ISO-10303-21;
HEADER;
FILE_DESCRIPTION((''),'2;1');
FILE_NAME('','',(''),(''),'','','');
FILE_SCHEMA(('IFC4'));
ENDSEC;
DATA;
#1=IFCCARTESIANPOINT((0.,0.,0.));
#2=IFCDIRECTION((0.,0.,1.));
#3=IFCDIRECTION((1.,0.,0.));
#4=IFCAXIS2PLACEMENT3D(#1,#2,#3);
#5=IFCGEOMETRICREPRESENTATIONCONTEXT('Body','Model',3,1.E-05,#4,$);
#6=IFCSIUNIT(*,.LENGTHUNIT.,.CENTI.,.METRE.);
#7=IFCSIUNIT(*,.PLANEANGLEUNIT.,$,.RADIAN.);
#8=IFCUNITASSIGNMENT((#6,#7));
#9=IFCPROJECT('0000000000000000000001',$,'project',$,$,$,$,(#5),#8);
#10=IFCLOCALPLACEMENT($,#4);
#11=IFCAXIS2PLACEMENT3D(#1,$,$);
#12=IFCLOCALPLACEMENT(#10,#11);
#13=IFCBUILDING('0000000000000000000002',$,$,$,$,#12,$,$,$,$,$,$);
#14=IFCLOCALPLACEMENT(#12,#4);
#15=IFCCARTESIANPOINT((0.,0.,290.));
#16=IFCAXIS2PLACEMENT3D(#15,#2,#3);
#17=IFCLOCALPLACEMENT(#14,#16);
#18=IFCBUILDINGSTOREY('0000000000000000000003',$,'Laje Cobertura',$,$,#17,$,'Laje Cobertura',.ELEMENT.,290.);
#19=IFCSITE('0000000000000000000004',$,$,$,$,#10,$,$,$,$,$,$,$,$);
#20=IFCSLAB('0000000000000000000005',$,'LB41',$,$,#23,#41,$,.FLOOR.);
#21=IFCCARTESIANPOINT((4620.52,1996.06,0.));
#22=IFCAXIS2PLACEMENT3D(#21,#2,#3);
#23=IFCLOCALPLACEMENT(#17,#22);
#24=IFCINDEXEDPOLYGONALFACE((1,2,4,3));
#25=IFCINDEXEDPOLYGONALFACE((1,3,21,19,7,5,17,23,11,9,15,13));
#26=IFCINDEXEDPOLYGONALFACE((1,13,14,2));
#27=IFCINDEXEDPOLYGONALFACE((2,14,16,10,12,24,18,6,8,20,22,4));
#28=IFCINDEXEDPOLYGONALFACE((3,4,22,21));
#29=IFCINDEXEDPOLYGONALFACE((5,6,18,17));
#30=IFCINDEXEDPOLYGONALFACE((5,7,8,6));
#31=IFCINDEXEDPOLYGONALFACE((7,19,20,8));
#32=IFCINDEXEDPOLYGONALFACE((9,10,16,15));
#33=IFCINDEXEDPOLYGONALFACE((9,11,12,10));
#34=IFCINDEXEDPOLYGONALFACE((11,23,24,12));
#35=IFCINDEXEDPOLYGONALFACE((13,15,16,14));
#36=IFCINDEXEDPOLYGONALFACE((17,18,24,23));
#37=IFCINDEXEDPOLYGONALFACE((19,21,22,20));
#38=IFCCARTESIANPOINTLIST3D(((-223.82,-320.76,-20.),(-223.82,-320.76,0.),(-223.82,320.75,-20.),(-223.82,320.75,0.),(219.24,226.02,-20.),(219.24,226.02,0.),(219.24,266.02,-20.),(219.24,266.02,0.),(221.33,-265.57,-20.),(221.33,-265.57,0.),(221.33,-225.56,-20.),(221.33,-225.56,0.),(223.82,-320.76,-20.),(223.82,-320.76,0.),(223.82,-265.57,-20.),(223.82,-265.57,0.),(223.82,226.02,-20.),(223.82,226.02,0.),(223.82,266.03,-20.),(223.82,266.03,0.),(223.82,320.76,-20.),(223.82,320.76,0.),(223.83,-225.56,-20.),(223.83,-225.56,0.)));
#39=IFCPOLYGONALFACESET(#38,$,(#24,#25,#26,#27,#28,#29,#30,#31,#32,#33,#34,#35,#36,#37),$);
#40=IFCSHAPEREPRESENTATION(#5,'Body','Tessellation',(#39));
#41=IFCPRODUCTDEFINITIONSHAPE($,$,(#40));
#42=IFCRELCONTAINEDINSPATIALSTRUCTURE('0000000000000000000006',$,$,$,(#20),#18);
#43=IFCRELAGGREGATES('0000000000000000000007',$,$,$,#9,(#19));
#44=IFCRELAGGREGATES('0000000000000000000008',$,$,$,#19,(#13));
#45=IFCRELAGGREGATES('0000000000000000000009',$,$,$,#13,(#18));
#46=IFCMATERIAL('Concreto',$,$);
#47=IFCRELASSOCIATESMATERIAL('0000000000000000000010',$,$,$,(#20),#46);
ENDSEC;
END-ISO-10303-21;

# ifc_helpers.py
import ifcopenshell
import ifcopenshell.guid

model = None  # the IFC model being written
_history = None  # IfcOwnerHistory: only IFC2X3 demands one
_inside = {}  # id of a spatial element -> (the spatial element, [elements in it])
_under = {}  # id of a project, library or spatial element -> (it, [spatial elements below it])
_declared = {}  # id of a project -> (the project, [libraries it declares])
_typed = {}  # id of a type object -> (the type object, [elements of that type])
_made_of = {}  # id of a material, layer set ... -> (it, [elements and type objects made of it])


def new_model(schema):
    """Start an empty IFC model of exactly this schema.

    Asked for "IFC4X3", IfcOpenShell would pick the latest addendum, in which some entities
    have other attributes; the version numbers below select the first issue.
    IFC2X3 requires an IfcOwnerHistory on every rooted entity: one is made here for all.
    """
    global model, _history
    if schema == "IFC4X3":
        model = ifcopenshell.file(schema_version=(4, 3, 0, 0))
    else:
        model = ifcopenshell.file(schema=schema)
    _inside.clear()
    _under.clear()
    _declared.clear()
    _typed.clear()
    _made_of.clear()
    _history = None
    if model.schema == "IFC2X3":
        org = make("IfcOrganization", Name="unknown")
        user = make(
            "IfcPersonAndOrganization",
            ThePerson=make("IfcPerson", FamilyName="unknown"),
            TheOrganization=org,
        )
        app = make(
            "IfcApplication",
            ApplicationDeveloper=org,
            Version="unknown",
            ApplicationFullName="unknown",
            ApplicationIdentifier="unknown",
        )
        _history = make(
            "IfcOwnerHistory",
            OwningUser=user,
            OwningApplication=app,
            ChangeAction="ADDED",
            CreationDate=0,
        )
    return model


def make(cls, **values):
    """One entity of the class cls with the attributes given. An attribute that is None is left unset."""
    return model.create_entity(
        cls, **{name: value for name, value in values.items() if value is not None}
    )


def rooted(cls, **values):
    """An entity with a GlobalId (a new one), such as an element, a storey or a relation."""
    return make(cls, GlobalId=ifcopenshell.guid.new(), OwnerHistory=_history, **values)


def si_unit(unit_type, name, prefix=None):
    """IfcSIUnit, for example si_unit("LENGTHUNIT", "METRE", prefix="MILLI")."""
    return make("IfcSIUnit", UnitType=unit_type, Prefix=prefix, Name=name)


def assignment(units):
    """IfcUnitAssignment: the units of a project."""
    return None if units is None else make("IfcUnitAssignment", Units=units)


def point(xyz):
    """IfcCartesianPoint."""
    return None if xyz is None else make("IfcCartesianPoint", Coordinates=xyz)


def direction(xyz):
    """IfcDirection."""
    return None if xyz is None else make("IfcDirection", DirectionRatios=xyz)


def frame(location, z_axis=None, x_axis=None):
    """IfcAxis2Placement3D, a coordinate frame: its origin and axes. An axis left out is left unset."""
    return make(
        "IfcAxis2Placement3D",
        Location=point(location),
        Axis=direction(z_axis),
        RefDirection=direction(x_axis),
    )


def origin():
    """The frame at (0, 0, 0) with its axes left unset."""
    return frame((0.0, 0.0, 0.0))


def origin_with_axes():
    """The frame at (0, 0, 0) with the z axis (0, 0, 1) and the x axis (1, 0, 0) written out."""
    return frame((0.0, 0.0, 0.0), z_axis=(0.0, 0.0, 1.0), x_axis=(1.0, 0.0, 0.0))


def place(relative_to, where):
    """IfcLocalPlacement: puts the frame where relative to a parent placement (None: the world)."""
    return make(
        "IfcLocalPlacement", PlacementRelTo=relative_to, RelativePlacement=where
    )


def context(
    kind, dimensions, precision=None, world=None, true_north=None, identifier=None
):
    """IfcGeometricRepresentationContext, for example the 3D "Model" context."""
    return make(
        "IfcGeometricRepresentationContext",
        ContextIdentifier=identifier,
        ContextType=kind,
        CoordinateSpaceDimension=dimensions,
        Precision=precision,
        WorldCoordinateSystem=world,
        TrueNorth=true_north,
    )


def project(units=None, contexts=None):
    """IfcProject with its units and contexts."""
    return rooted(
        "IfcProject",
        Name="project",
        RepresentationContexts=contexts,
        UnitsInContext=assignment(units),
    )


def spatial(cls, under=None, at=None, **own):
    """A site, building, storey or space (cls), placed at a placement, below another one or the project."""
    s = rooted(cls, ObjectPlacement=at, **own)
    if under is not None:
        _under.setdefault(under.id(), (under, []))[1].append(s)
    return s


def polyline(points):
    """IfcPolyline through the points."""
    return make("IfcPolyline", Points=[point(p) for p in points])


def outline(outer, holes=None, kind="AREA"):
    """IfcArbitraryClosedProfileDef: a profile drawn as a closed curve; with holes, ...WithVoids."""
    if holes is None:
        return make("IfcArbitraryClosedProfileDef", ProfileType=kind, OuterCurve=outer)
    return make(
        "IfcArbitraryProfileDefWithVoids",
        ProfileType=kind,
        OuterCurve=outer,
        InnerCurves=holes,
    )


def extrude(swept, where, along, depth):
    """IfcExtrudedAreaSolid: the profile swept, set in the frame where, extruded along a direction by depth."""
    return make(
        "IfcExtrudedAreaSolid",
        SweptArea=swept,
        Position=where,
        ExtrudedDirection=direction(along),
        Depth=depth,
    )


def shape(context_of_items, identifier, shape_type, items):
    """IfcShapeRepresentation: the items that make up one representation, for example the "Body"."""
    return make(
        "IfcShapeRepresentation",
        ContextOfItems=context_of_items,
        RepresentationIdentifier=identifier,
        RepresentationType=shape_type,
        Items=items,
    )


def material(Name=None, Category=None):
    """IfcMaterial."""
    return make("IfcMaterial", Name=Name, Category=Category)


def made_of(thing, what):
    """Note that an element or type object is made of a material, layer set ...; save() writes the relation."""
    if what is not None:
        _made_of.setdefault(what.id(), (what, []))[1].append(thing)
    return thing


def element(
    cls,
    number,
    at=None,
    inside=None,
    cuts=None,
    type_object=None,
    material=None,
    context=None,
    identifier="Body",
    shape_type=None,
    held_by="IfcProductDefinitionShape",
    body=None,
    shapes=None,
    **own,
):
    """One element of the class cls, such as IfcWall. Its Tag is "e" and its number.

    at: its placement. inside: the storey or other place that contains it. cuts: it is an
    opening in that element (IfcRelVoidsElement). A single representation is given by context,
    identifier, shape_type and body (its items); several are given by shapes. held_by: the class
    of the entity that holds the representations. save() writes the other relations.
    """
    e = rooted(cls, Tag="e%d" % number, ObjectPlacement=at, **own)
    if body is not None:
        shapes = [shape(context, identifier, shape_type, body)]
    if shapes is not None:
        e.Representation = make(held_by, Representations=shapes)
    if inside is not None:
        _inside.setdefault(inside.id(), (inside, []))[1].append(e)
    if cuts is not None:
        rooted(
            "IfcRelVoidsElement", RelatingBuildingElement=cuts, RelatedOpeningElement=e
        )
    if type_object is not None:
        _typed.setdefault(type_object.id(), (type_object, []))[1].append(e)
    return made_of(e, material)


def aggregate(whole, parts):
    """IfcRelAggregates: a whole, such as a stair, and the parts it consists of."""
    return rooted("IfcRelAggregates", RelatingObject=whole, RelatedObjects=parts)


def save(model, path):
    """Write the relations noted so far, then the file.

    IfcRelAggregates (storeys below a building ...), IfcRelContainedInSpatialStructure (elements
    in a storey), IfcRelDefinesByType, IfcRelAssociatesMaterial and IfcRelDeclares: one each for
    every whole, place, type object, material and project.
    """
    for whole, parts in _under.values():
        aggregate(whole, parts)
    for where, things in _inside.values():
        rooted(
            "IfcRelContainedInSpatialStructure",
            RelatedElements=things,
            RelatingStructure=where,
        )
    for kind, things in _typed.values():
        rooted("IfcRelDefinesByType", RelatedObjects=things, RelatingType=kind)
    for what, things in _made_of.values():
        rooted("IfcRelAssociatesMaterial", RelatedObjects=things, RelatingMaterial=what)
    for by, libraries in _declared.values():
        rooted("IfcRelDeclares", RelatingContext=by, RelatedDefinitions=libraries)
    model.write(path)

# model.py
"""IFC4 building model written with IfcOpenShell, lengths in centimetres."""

from ifc_helpers import new_model, si_unit, frame, origin, origin_with_axes, place, context, project, spatial, polyline, outline, extrude, material, element, save


model = new_model("IFC4")

# Units and contexts
model_context = context("Model", 3, precision=1e-05, world=origin_with_axes(), identifier="Body")
ifc_project = project(units=[si_unit("LENGTHUNIT", "METRE", prefix="CENTI"), si_unit("PLANEANGLEUNIT", "RADIAN")], contexts=[model_context])

# Site, building, storey
site_placement = place(None, origin_with_axes())
site = spatial("IfcSite", under=ifc_project, at=site_placement)
building_placement = place(site_placement, origin())
building = spatial("IfcBuilding", under=site, at=building_placement)
placement = place(building_placement, origin_with_axes())
storey_placement = place(placement, frame((0.0, 0.0, 290.0), z_axis=(0.0, 0.0, 1.0), x_axis=(1.0, 0.0, 0.0)))
storey = spatial("IfcBuildingStorey", under=building, at=storey_placement, Name="Laje Cobertura", LongName="Laje Cobertura", CompositionType="ELEMENT", Elevation=290.0)

# Shared definitions
ifc_material = material(Name="Concreto")

# Slab
slab_1_placement = place(storey_placement, frame((4620.52, 1996.06, 0.0), z_axis=(0.0, 0.0, 1.0), x_axis=(1.0, 0.0, 0.0)))
element("IfcSlab", 1, at=slab_1_placement, inside=storey, material=ifc_material, Name="LB41", PredefinedType="FLOOR", context=model_context, shape_type="SolidModel", body=[
    extrude(outline(polyline([(223.82, -265.56), (221.32, -265.56), (221.32, -225.56), (223.82, -225.56), (223.82, 226.02), (219.25, 226.02), (219.25, 266.02), (223.82, 266.02), (223.82, 320.75), (-223.82, 320.75), (-223.82, -320.75), (223.82, -320.75), (223.82, -265.56), (223.82, -265.56)])), frame((0.0, 0.0, -20.0), z_axis=(0.0, 0.0, 1.0), x_axis=(1.0, 0.0, 0.0)), (0.0, 0.0, 1.0), 20.0),
])

save(model, "model.ifc")
